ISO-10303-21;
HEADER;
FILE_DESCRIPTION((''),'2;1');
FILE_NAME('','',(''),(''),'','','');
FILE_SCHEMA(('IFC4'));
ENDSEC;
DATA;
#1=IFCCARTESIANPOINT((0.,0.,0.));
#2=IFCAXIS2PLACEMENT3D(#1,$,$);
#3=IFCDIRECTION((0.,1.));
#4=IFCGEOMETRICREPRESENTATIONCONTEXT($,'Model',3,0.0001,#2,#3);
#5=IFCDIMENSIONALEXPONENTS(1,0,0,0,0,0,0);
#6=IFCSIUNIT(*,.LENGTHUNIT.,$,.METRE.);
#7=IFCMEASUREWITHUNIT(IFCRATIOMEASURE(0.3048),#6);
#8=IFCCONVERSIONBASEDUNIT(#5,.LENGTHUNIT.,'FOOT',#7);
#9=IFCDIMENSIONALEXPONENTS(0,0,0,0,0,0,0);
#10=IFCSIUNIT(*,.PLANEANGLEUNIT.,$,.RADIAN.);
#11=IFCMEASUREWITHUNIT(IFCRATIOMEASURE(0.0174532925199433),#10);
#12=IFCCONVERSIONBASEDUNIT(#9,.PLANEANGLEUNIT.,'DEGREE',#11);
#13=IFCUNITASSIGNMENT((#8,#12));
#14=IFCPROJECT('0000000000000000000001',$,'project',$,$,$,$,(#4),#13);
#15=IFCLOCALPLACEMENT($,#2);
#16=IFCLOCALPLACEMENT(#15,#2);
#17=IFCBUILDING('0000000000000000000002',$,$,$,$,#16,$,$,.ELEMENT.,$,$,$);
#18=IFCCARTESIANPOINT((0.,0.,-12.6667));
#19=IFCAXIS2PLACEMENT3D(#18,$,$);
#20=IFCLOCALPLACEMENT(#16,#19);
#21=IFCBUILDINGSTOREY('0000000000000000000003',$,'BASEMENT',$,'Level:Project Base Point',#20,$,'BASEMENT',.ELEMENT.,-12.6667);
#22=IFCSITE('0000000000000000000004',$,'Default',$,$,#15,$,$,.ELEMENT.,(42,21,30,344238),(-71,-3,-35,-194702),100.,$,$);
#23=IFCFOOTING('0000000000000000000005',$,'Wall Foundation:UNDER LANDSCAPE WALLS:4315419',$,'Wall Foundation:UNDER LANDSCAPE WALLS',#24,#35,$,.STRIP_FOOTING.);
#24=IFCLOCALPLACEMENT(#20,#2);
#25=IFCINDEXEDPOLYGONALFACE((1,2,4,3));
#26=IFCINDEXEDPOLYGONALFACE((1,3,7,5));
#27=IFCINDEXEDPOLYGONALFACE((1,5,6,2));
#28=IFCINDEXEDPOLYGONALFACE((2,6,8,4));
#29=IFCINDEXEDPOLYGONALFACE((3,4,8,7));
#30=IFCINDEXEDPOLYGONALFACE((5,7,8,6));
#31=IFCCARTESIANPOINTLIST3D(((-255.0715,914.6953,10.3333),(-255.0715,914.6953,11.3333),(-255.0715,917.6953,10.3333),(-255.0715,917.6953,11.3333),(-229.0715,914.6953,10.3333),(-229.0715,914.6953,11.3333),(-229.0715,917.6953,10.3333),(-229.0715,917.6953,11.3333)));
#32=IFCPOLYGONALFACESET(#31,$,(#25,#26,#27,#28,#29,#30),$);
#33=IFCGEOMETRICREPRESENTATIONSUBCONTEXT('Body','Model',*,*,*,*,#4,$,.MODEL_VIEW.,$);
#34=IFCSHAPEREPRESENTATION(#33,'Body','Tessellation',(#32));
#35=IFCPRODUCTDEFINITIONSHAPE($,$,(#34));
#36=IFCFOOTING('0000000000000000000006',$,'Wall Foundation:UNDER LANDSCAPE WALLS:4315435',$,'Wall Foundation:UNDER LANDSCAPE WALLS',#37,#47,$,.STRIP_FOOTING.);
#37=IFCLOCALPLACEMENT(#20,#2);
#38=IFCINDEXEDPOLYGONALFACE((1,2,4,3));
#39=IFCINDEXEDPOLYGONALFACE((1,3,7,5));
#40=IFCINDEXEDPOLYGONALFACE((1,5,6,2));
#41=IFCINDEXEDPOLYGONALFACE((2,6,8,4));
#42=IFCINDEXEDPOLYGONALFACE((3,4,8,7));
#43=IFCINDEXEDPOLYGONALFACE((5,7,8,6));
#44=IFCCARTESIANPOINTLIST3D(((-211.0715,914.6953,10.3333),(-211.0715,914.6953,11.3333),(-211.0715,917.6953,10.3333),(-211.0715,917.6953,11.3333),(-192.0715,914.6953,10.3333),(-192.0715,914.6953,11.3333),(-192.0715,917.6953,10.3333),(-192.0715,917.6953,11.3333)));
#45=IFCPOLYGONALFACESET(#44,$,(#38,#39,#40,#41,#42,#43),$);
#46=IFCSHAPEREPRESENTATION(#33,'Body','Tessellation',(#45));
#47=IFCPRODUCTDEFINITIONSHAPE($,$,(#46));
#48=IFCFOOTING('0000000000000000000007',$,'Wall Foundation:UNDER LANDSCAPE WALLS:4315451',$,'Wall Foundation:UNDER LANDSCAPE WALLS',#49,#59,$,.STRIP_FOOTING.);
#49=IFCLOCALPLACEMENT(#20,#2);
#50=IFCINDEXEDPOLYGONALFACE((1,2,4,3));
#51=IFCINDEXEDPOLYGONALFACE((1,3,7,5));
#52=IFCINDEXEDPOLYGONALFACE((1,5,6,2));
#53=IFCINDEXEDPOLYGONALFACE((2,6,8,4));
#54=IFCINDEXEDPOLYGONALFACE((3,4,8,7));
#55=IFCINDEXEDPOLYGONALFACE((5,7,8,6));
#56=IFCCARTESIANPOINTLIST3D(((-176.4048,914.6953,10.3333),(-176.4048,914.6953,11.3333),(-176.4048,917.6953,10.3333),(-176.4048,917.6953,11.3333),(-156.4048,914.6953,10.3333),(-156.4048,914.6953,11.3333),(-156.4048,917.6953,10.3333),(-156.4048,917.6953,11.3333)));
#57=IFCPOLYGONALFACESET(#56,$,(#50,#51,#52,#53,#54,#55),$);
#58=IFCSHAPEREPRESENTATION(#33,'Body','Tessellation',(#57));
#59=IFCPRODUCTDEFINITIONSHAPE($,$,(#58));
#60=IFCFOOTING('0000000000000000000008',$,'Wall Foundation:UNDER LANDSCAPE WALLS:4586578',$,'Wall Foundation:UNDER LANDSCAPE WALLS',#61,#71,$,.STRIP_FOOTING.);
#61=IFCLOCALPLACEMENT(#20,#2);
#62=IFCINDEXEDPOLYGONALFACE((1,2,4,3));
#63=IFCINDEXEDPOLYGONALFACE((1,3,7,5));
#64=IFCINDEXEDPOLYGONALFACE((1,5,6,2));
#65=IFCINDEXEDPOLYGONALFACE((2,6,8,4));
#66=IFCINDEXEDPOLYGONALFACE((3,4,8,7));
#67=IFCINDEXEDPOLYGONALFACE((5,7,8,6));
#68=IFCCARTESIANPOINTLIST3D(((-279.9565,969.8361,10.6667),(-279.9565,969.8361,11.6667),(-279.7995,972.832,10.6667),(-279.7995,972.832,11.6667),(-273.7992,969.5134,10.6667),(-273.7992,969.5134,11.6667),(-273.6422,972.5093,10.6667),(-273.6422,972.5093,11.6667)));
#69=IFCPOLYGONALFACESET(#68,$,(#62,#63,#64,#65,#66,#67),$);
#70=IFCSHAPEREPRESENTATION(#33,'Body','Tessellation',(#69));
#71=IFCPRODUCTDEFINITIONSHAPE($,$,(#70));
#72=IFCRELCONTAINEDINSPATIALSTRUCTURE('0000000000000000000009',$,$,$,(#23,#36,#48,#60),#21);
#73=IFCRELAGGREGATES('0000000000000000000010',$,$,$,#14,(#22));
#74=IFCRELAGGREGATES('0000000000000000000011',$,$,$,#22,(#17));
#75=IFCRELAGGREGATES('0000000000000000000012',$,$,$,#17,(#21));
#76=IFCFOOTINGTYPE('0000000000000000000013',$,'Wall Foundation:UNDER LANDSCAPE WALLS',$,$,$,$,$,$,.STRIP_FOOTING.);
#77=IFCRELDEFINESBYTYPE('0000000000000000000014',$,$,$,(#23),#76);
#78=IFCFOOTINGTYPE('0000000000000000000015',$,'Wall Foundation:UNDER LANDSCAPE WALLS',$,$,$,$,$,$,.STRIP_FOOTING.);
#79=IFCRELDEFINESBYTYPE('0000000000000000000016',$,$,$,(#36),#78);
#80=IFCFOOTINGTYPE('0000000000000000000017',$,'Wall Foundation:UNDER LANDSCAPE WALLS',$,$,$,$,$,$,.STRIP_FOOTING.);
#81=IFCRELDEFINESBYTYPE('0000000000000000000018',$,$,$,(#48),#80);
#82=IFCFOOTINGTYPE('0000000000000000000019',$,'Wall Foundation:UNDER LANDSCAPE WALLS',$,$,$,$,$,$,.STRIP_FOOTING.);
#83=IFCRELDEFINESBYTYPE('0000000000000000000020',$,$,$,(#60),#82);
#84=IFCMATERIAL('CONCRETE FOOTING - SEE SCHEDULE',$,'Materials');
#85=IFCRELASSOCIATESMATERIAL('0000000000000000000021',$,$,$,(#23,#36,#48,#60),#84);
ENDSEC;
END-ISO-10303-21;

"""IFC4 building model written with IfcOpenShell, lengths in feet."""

from ifc_helpers import new_model, entity, si_unit, converted_unit, direction, frame, frame_2d, origin, origin_2d_with_axis, place, context, subcontext, project, spatial, rectangle, extrude, material, type_object, element, save


model = new_model("IFC4")

# Units and contexts
model_context = context("Model", 3, precision=0.0001, world=origin(), true_north=direction((0.0, 1.0)))
body_context = subcontext(model_context, "Body", "Model", "MODEL_VIEW")
ifc_project = project(units=[converted_unit("LENGTHUNIT", "FOOT", entity("IfcRatioMeasure", 0.3048), si_unit("LENGTHUNIT", "METRE"), dimensions=[1, 0, 0, 0, 0, 0, 0]), converted_unit("PLANEANGLEUNIT", "DEGREE", entity("IfcRatioMeasure", 0.0174532925199433), si_unit("PLANEANGLEUNIT", "RADIAN"), dimensions=[0, 0, 0, 0, 0, 0, 0])], contexts=[model_context])

# Site, building, storey
site_placement = place(None, origin())
site = spatial("IfcSite", under=ifc_project, at=site_placement, Name="Default", CompositionType="ELEMENT", RefLatitude=(42, 21, 30, 344238), RefLongitude=(-71, -3, -35, -194702), RefElevation=100.0)
building_placement = place(site_placement, origin())
building = spatial("IfcBuilding", under=site, at=building_placement, CompositionType="ELEMENT")
storey_placement = place(building_placement, frame((0.0, 0.0, -12.6667)))
storey = spatial("IfcBuildingStorey", under=building, at=storey_placement, Name="BASEMENT", ObjectType="Level:Project Base Point", LongName="BASEMENT", CompositionType="ELEMENT", Elevation=-12.6667)

# Footings
ifc_material = material(Name="CONCRETE FOOTING - SEE SCHEDULE", Category="Materials")
footing_type_1 = type_object("IfcFootingType", Name="Wall Foundation:UNDER LANDSCAPE WALLS", PredefinedType="STRIP_FOOTING")
footing_1_placement = place(storey_placement, frame((-255.0715, 914.6953, 10.3333)))
element("IfcFooting", 1, at=footing_1_placement, inside=storey, type_object=footing_type_1, material=ifc_material, Name="Wall Foundation:UNDER LANDSCAPE WALLS:4315419", ObjectType="Wall Foundation:UNDER LANDSCAPE WALLS", PredefinedType="STRIP_FOOTING", context=body_context, shape_type="SweptSolid", body=[
    extrude(rectangle(XDim=26.0, YDim=3.0, at=origin_2d_with_axis()), frame((13.0, 1.5, 0.0), z_axis=(0.0, 0.0, 1.0), x_axis=(-1.0, 0.0, 0.0)), (0.0, 0.0, 1.0), 1.0),
])
footing_type_2 = type_object("IfcFootingType", Name="Wall Foundation:UNDER LANDSCAPE WALLS", PredefinedType="STRIP_FOOTING")
footing_2_placement = place(storey_placement, frame((-211.0715, 914.6953, 10.3333)))
element("IfcFooting", 2, at=footing_2_placement, inside=storey, type_object=footing_type_2, material=ifc_material, Name="Wall Foundation:UNDER LANDSCAPE WALLS:4315435", ObjectType="Wall Foundation:UNDER LANDSCAPE WALLS", PredefinedType="STRIP_FOOTING", context=body_context, shape_type="SweptSolid", body=[
    extrude(rectangle(XDim=19.0, YDim=3.0, at=origin_2d_with_axis()), frame((9.5, 1.5, 0.0), z_axis=(0.0, 0.0, 1.0), x_axis=(-1.0, 0.0, 0.0)), (0.0, 0.0, 1.0), 1.0),
])
footing_type_3 = type_object("IfcFootingType", Name="Wall Foundation:UNDER LANDSCAPE WALLS", PredefinedType="STRIP_FOOTING")
footing_3_placement = place(storey_placement, frame((-176.4048, 914.6953, 10.3333)))
element("IfcFooting", 3, at=footing_3_placement, inside=storey, type_object=footing_type_3, material=ifc_material, Name="Wall Foundation:UNDER LANDSCAPE WALLS:4315451", ObjectType="Wall Foundation:UNDER LANDSCAPE WALLS", PredefinedType="STRIP_FOOTING", context=body_context, shape_type="SweptSolid", body=[
    extrude(rectangle(XDim=20.0, YDim=3.0, at=origin_2d_with_axis()), frame((10.0, 1.5, 0.0), z_axis=(0.0, 0.0, 1.0), x_axis=(-1.0, 0.0, 0.0)), (0.0, 0.0, 1.0), 1.0),
])
footing_type_4 = type_object("IfcFootingType", Name="Wall Foundation:UNDER LANDSCAPE WALLS", PredefinedType="STRIP_FOOTING")
footing_4_placement = place(storey_placement, frame((-279.9565, 969.5134, 10.6667)))
element("IfcFooting", 4, at=footing_4_placement, inside=storey, type_object=footing_type_4, material=ifc_material, Name="Wall Foundation:UNDER LANDSCAPE WALLS:4586578", ObjectType="Wall Foundation:UNDER LANDSCAPE WALLS", PredefinedType="STRIP_FOOTING", context=body_context, shape_type="SweptSolid", body=[
    extrude(rectangle(XDim=6.1658, YDim=3.0, at=frame_2d((0.0, 0.0), x_axis=(1.0, 0.0))), frame((3.1572, 1.6593, 0.0), z_axis=(0.0, 0.0, 1.0), x_axis=(-0.99863, 0.052336, 0.0)), (0.0, 0.0, 1.0), 1.0),
])

save(model, "model.ifc")
